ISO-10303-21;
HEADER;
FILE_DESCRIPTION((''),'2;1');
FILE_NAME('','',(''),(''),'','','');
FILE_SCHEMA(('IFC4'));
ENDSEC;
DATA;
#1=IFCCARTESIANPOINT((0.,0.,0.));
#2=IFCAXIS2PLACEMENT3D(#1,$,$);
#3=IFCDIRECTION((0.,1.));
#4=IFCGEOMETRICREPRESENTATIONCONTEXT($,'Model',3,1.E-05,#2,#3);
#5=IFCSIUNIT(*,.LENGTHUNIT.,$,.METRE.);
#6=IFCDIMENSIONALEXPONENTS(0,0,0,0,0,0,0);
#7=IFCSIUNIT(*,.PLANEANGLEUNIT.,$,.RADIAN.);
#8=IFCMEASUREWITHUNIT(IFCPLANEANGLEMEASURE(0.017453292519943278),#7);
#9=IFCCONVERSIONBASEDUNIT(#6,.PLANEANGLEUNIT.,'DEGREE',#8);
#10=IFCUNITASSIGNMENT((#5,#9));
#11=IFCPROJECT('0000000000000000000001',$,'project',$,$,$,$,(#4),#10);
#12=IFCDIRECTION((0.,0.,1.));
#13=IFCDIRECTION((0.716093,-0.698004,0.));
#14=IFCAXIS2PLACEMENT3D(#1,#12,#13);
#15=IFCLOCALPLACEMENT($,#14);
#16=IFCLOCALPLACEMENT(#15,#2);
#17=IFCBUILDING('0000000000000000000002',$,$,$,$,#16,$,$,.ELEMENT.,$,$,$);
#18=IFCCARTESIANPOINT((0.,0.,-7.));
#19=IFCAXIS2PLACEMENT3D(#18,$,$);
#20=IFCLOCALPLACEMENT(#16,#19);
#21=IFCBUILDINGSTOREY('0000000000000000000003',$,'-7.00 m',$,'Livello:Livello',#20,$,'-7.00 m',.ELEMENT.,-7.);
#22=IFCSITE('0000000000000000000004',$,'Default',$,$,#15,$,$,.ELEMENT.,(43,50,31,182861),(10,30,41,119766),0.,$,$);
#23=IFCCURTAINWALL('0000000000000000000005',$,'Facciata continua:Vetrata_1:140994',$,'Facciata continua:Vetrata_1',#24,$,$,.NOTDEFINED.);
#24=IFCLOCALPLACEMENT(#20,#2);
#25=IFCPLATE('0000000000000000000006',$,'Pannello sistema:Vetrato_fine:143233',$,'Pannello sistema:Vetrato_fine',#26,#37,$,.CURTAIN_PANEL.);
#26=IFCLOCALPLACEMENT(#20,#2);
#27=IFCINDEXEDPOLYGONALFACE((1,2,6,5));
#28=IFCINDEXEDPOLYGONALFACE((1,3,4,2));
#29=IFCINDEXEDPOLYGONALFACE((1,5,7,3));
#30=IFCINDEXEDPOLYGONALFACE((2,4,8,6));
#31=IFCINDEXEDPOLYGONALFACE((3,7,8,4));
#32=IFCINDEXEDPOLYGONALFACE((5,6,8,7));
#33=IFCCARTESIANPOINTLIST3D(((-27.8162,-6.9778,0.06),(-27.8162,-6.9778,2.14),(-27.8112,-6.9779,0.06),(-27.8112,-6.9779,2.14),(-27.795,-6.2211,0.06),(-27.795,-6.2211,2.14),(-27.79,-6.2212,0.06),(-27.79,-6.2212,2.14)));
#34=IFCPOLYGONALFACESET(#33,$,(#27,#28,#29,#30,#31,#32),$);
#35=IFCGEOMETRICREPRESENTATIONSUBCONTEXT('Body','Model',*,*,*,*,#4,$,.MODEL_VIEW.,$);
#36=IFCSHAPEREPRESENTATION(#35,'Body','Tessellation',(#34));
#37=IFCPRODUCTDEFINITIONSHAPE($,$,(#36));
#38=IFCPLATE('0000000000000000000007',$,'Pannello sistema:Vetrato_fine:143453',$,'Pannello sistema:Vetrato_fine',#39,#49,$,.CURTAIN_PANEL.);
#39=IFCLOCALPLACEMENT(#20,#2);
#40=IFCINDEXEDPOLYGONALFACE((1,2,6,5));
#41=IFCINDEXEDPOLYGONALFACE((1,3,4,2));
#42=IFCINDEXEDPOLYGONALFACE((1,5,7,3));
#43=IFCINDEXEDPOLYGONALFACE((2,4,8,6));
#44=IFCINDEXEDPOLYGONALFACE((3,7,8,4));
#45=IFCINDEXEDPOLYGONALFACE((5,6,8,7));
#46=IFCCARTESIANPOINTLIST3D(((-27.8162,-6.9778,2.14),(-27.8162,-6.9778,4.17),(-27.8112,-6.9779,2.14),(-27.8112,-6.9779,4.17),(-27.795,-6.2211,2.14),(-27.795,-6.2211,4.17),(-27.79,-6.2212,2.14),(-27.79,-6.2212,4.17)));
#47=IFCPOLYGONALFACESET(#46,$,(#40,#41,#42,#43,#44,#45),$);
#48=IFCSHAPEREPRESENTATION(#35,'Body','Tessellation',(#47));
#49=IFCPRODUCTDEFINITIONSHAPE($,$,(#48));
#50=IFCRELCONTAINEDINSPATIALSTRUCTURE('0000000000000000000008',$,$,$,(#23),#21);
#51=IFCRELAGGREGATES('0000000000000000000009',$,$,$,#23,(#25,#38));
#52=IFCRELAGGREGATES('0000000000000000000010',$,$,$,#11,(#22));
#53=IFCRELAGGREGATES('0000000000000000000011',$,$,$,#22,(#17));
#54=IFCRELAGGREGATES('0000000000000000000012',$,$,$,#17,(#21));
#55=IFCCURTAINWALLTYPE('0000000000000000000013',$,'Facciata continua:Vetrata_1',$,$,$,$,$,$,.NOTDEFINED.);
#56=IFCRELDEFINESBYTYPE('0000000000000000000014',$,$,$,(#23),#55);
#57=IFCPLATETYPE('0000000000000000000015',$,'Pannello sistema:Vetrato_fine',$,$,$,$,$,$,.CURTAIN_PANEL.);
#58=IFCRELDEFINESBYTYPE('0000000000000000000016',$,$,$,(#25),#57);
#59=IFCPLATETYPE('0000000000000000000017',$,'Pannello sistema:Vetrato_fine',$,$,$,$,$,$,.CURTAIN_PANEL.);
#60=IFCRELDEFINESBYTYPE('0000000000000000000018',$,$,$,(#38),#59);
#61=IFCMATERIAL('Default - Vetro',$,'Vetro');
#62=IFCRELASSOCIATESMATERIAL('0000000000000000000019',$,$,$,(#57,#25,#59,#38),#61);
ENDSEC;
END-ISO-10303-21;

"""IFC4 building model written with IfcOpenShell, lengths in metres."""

from ifc_helpers import new_model, entity, si_unit, converted_unit, direction, frame, origin, place, context, subcontext, project, spatial, indexed_curve, outline, extrude, source, transform, mapped, material, type_object, type_shapes, element, aggregate, save


model = new_model("IFC4")

# Units and contexts
model_context = context("Model", 3, precision=1e-05, world=origin(), true_north=direction((0.0, 1.0)))
body_context = subcontext(model_context, "Body", "Model", "MODEL_VIEW")
ifc_project = project(units=[si_unit("LENGTHUNIT", "METRE"), converted_unit("PLANEANGLEUNIT", "DEGREE", entity("IfcPlaneAngleMeasure", 0.017453292519943278), si_unit("PLANEANGLEUNIT", "RADIAN"), dimensions=[0, 0, 0, 0, 0, 0, 0])], contexts=[model_context])

# Site, building, storey
site_placement = place(None, frame((0.0, 0.0, 0.0), z_axis=(0.0, 0.0, 1.0), x_axis=(0.716093, -0.698004, 0.0)))
site = spatial("IfcSite", under=ifc_project, at=site_placement, Name="Default", CompositionType="ELEMENT", RefLatitude=(43, 50, 31, 182861), RefLongitude=(10, 30, 41, 119766), RefElevation=0.0)
building_placement = place(site_placement, origin())
building = spatial("IfcBuilding", under=site, at=building_placement, CompositionType="ELEMENT")
storey_placement = place(building_placement, frame((0.0, 0.0, -7.0)))
storey = spatial("IfcBuildingStorey", under=building, at=storey_placement, Name="-7.00 m", ObjectType="Livello:Livello", LongName="-7.00 m", CompositionType="ELEMENT", Elevation=-7.0)

# Curtain wall
curtain_wall_type_1 = type_object("IfcCurtainWallType", Name="Facciata continua:Vetrata_1", PredefinedType="NOTDEFINED")
curtain_wall_1_placement = place(storey_placement, frame((0.0, 0.0, 7.0)))
curtain_wall_1 = element("IfcCurtainWall", 1, at=curtain_wall_1_placement, inside=storey, type_object=curtain_wall_type_1, Name="Facciata continua:Vetrata_1:140994", ObjectType="Facciata continua:Vetrata_1", PredefinedType="NOTDEFINED")

# Plates
ifc_material_1 = material(Name="Default - Vetro", Category="Vetro")
plate_type_1 = type_object("IfcPlateType", Name="Pannello sistema:Vetrato_fine", PredefinedType="CURTAIN_PANEL", material=ifc_material_1)
shared_shape_1 = source(origin(), body_context, "Body", "SweptSolid", [
    extrude(outline(indexed_curve([(-0.0025, -0.3785), (0.0025, -0.3785), (0.0025, 0.3785), (-0.0025, 0.3785), (-0.0025, -0.3785)], self_intersect=False)), frame((0.0, 0.0, 0.0), z_axis=(0.0, 0.0, 1.0), x_axis=(0.0, 1.0, 0.0)), (0.0, 0.0, 1.0), 2.08),
])
type_shapes(plate_type_1, [shared_shape_1])
plate_1_placement = place(curtain_wall_1_placement, frame((-27.8031, -6.5995, -6.94), z_axis=(0.0, 0.0, 1.0), x_axis=(-0.02798, -0.999608, 0.0)))
plate_1 = element("IfcPlate", 2, at=plate_1_placement, type_object=plate_type_1, material=ifc_material_1, Name="Pannello sistema:Vetrato_fine:143233", ObjectType="Pannello sistema:Vetrato_fine", PredefinedType="CURTAIN_PANEL", context=body_context, shape_type="MappedRepresentation", body=[
    mapped(shared_shape_1, transform((0.0, 0.0, 0.0), scale=1.0)),
])
plate_type_2 = type_object("IfcPlateType", Name="Pannello sistema:Vetrato_fine", PredefinedType="CURTAIN_PANEL", material=ifc_material_1)
shared_shape_2 = source(origin(), body_context, "Body", "SweptSolid", [
    extrude(outline(indexed_curve([(-0.0025, -0.3785), (0.0025, -0.3785), (0.0025, 0.3785), (-0.0025, 0.3785), (-0.0025, -0.3785)], self_intersect=False)), frame((0.0, 0.0, 0.0), z_axis=(0.0, 0.0, 1.0), x_axis=(0.0, 1.0, 0.0)), (0.0, 0.0, 1.0), 2.03),
])
type_shapes(plate_type_2, [shared_shape_2])
plate_2_placement = place(curtain_wall_1_placement, frame((-27.8031, -6.5995, -4.86), z_axis=(0.0, 0.0, 1.0), x_axis=(-0.02798, -0.999608, 0.0)))
plate_2 = element("IfcPlate", 3, at=plate_2_placement, type_object=plate_type_2, material=ifc_material_1, Name="Pannello sistema:Vetrato_fine:143453", ObjectType="Pannello sistema:Vetrato_fine", PredefinedType="CURTAIN_PANEL", context=body_context, shape_type="MappedRepresentation", body=[
    mapped(shared_shape_2, transform((0.0, 0.0, 0.0), scale=1.0)),
])
aggregate(curtain_wall_1, [plate_1, plate_2])

save(model, "model.ifc")
